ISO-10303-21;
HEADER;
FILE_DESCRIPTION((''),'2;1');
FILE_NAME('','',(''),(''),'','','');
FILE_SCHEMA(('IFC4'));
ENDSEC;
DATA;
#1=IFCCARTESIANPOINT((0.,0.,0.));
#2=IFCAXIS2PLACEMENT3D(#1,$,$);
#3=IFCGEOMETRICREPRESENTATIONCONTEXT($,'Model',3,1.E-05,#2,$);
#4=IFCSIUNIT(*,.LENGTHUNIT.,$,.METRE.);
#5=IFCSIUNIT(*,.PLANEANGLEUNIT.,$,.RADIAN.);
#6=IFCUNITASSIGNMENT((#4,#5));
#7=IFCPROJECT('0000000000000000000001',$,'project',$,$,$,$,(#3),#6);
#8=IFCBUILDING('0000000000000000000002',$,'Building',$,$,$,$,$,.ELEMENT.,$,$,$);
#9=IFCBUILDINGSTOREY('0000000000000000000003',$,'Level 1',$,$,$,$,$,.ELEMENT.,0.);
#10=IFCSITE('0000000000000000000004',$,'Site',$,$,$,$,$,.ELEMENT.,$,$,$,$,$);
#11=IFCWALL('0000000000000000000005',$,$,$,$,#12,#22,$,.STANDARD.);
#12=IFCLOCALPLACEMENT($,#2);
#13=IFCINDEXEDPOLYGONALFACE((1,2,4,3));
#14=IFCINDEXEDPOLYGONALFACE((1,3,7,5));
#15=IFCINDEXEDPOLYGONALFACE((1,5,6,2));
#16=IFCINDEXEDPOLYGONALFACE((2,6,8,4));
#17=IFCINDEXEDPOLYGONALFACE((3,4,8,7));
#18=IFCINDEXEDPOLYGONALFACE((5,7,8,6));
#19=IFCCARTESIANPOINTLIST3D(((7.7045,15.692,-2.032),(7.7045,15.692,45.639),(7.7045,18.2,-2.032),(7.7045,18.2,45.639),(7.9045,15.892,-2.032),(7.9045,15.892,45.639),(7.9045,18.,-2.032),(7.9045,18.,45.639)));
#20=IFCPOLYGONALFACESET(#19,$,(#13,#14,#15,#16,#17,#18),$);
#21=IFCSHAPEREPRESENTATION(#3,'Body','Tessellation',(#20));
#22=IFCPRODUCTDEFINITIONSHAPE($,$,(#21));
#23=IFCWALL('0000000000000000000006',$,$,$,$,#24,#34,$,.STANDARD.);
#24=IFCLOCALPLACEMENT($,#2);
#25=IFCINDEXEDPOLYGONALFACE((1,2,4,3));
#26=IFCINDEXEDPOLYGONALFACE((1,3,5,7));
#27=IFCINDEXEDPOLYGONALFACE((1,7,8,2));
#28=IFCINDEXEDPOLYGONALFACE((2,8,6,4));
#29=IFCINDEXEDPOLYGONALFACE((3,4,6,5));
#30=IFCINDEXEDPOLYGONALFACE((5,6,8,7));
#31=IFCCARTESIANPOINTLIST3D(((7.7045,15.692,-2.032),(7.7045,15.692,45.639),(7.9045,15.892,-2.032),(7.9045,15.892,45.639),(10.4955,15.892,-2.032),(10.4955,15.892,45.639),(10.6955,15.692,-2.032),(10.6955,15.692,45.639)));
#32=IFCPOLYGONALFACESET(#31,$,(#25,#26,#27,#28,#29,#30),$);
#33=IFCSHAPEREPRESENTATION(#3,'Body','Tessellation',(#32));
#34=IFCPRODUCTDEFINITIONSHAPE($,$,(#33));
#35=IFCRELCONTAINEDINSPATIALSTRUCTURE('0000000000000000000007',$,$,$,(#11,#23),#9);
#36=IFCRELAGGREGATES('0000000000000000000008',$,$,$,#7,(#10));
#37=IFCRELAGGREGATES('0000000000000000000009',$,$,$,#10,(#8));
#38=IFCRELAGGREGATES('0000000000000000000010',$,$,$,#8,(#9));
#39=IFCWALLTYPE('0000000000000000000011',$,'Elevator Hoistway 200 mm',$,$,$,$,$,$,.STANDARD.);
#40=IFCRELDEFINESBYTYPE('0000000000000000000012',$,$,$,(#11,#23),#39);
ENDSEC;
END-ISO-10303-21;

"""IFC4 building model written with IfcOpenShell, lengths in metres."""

from ifc_helpers import new_model, si_unit, frame, origin, place, context, project, spatial, polyline, outline, extrude, type_object, element, save


model = new_model("IFC4")

# Units and contexts
model_context = context("Model", 3, precision=1e-05, world=origin())
ifc_project = project(units=[si_unit("LENGTHUNIT", "METRE"), si_unit("PLANEANGLEUNIT", "RADIAN")], contexts=[model_context])

# Site, building, storey
site = spatial("IfcSite", under=ifc_project, Name="Site", CompositionType="ELEMENT")
building = spatial("IfcBuilding", under=site, Name="Building", CompositionType="ELEMENT")
storey = spatial("IfcBuildingStorey", under=building, Name="Level 1", CompositionType="ELEMENT", Elevation=0.0)

# Shared definitions
wall_type = type_object("IfcWallType", Name="Elevator Hoistway 200 mm", PredefinedType="STANDARD")

# Walls
wall_1_placement = place(None, frame((7.8045, 18.1, -2.032), z_axis=(0.0, 0.0, 1.0), x_axis=(0.0, -1.0, 0.0)))
element("IfcWall", 1, at=wall_1_placement, inside=storey, type_object=wall_type, PredefinedType="STANDARD", context=model_context, shape_type="SweptSolid", body=[
    extrude(outline(polyline([(-0.1, -0.1), (2.408, -0.1), (2.208, 0.1), (0.1, 0.1), (-0.1, -0.1)])), origin(), (0.0, 0.0, 1.0), 47.671),
])
wall_2_placement = place(None, frame((7.8045, 15.792, -2.032), z_axis=(0.0, 0.0, 1.0), x_axis=(1.0, 0.0, 0.0)))
element("IfcWall", 2, at=wall_2_placement, inside=storey, type_object=wall_type, PredefinedType="STANDARD", context=model_context, shape_type="SweptSolid", body=[
    extrude(outline(polyline([(-0.1, -0.1), (2.891, -0.1), (2.691, 0.1), (0.1, 0.1), (-0.1, -0.1)])), origin(), (0.0, 0.0, 1.0), 47.671),
])

save(model, "model.ifc")
